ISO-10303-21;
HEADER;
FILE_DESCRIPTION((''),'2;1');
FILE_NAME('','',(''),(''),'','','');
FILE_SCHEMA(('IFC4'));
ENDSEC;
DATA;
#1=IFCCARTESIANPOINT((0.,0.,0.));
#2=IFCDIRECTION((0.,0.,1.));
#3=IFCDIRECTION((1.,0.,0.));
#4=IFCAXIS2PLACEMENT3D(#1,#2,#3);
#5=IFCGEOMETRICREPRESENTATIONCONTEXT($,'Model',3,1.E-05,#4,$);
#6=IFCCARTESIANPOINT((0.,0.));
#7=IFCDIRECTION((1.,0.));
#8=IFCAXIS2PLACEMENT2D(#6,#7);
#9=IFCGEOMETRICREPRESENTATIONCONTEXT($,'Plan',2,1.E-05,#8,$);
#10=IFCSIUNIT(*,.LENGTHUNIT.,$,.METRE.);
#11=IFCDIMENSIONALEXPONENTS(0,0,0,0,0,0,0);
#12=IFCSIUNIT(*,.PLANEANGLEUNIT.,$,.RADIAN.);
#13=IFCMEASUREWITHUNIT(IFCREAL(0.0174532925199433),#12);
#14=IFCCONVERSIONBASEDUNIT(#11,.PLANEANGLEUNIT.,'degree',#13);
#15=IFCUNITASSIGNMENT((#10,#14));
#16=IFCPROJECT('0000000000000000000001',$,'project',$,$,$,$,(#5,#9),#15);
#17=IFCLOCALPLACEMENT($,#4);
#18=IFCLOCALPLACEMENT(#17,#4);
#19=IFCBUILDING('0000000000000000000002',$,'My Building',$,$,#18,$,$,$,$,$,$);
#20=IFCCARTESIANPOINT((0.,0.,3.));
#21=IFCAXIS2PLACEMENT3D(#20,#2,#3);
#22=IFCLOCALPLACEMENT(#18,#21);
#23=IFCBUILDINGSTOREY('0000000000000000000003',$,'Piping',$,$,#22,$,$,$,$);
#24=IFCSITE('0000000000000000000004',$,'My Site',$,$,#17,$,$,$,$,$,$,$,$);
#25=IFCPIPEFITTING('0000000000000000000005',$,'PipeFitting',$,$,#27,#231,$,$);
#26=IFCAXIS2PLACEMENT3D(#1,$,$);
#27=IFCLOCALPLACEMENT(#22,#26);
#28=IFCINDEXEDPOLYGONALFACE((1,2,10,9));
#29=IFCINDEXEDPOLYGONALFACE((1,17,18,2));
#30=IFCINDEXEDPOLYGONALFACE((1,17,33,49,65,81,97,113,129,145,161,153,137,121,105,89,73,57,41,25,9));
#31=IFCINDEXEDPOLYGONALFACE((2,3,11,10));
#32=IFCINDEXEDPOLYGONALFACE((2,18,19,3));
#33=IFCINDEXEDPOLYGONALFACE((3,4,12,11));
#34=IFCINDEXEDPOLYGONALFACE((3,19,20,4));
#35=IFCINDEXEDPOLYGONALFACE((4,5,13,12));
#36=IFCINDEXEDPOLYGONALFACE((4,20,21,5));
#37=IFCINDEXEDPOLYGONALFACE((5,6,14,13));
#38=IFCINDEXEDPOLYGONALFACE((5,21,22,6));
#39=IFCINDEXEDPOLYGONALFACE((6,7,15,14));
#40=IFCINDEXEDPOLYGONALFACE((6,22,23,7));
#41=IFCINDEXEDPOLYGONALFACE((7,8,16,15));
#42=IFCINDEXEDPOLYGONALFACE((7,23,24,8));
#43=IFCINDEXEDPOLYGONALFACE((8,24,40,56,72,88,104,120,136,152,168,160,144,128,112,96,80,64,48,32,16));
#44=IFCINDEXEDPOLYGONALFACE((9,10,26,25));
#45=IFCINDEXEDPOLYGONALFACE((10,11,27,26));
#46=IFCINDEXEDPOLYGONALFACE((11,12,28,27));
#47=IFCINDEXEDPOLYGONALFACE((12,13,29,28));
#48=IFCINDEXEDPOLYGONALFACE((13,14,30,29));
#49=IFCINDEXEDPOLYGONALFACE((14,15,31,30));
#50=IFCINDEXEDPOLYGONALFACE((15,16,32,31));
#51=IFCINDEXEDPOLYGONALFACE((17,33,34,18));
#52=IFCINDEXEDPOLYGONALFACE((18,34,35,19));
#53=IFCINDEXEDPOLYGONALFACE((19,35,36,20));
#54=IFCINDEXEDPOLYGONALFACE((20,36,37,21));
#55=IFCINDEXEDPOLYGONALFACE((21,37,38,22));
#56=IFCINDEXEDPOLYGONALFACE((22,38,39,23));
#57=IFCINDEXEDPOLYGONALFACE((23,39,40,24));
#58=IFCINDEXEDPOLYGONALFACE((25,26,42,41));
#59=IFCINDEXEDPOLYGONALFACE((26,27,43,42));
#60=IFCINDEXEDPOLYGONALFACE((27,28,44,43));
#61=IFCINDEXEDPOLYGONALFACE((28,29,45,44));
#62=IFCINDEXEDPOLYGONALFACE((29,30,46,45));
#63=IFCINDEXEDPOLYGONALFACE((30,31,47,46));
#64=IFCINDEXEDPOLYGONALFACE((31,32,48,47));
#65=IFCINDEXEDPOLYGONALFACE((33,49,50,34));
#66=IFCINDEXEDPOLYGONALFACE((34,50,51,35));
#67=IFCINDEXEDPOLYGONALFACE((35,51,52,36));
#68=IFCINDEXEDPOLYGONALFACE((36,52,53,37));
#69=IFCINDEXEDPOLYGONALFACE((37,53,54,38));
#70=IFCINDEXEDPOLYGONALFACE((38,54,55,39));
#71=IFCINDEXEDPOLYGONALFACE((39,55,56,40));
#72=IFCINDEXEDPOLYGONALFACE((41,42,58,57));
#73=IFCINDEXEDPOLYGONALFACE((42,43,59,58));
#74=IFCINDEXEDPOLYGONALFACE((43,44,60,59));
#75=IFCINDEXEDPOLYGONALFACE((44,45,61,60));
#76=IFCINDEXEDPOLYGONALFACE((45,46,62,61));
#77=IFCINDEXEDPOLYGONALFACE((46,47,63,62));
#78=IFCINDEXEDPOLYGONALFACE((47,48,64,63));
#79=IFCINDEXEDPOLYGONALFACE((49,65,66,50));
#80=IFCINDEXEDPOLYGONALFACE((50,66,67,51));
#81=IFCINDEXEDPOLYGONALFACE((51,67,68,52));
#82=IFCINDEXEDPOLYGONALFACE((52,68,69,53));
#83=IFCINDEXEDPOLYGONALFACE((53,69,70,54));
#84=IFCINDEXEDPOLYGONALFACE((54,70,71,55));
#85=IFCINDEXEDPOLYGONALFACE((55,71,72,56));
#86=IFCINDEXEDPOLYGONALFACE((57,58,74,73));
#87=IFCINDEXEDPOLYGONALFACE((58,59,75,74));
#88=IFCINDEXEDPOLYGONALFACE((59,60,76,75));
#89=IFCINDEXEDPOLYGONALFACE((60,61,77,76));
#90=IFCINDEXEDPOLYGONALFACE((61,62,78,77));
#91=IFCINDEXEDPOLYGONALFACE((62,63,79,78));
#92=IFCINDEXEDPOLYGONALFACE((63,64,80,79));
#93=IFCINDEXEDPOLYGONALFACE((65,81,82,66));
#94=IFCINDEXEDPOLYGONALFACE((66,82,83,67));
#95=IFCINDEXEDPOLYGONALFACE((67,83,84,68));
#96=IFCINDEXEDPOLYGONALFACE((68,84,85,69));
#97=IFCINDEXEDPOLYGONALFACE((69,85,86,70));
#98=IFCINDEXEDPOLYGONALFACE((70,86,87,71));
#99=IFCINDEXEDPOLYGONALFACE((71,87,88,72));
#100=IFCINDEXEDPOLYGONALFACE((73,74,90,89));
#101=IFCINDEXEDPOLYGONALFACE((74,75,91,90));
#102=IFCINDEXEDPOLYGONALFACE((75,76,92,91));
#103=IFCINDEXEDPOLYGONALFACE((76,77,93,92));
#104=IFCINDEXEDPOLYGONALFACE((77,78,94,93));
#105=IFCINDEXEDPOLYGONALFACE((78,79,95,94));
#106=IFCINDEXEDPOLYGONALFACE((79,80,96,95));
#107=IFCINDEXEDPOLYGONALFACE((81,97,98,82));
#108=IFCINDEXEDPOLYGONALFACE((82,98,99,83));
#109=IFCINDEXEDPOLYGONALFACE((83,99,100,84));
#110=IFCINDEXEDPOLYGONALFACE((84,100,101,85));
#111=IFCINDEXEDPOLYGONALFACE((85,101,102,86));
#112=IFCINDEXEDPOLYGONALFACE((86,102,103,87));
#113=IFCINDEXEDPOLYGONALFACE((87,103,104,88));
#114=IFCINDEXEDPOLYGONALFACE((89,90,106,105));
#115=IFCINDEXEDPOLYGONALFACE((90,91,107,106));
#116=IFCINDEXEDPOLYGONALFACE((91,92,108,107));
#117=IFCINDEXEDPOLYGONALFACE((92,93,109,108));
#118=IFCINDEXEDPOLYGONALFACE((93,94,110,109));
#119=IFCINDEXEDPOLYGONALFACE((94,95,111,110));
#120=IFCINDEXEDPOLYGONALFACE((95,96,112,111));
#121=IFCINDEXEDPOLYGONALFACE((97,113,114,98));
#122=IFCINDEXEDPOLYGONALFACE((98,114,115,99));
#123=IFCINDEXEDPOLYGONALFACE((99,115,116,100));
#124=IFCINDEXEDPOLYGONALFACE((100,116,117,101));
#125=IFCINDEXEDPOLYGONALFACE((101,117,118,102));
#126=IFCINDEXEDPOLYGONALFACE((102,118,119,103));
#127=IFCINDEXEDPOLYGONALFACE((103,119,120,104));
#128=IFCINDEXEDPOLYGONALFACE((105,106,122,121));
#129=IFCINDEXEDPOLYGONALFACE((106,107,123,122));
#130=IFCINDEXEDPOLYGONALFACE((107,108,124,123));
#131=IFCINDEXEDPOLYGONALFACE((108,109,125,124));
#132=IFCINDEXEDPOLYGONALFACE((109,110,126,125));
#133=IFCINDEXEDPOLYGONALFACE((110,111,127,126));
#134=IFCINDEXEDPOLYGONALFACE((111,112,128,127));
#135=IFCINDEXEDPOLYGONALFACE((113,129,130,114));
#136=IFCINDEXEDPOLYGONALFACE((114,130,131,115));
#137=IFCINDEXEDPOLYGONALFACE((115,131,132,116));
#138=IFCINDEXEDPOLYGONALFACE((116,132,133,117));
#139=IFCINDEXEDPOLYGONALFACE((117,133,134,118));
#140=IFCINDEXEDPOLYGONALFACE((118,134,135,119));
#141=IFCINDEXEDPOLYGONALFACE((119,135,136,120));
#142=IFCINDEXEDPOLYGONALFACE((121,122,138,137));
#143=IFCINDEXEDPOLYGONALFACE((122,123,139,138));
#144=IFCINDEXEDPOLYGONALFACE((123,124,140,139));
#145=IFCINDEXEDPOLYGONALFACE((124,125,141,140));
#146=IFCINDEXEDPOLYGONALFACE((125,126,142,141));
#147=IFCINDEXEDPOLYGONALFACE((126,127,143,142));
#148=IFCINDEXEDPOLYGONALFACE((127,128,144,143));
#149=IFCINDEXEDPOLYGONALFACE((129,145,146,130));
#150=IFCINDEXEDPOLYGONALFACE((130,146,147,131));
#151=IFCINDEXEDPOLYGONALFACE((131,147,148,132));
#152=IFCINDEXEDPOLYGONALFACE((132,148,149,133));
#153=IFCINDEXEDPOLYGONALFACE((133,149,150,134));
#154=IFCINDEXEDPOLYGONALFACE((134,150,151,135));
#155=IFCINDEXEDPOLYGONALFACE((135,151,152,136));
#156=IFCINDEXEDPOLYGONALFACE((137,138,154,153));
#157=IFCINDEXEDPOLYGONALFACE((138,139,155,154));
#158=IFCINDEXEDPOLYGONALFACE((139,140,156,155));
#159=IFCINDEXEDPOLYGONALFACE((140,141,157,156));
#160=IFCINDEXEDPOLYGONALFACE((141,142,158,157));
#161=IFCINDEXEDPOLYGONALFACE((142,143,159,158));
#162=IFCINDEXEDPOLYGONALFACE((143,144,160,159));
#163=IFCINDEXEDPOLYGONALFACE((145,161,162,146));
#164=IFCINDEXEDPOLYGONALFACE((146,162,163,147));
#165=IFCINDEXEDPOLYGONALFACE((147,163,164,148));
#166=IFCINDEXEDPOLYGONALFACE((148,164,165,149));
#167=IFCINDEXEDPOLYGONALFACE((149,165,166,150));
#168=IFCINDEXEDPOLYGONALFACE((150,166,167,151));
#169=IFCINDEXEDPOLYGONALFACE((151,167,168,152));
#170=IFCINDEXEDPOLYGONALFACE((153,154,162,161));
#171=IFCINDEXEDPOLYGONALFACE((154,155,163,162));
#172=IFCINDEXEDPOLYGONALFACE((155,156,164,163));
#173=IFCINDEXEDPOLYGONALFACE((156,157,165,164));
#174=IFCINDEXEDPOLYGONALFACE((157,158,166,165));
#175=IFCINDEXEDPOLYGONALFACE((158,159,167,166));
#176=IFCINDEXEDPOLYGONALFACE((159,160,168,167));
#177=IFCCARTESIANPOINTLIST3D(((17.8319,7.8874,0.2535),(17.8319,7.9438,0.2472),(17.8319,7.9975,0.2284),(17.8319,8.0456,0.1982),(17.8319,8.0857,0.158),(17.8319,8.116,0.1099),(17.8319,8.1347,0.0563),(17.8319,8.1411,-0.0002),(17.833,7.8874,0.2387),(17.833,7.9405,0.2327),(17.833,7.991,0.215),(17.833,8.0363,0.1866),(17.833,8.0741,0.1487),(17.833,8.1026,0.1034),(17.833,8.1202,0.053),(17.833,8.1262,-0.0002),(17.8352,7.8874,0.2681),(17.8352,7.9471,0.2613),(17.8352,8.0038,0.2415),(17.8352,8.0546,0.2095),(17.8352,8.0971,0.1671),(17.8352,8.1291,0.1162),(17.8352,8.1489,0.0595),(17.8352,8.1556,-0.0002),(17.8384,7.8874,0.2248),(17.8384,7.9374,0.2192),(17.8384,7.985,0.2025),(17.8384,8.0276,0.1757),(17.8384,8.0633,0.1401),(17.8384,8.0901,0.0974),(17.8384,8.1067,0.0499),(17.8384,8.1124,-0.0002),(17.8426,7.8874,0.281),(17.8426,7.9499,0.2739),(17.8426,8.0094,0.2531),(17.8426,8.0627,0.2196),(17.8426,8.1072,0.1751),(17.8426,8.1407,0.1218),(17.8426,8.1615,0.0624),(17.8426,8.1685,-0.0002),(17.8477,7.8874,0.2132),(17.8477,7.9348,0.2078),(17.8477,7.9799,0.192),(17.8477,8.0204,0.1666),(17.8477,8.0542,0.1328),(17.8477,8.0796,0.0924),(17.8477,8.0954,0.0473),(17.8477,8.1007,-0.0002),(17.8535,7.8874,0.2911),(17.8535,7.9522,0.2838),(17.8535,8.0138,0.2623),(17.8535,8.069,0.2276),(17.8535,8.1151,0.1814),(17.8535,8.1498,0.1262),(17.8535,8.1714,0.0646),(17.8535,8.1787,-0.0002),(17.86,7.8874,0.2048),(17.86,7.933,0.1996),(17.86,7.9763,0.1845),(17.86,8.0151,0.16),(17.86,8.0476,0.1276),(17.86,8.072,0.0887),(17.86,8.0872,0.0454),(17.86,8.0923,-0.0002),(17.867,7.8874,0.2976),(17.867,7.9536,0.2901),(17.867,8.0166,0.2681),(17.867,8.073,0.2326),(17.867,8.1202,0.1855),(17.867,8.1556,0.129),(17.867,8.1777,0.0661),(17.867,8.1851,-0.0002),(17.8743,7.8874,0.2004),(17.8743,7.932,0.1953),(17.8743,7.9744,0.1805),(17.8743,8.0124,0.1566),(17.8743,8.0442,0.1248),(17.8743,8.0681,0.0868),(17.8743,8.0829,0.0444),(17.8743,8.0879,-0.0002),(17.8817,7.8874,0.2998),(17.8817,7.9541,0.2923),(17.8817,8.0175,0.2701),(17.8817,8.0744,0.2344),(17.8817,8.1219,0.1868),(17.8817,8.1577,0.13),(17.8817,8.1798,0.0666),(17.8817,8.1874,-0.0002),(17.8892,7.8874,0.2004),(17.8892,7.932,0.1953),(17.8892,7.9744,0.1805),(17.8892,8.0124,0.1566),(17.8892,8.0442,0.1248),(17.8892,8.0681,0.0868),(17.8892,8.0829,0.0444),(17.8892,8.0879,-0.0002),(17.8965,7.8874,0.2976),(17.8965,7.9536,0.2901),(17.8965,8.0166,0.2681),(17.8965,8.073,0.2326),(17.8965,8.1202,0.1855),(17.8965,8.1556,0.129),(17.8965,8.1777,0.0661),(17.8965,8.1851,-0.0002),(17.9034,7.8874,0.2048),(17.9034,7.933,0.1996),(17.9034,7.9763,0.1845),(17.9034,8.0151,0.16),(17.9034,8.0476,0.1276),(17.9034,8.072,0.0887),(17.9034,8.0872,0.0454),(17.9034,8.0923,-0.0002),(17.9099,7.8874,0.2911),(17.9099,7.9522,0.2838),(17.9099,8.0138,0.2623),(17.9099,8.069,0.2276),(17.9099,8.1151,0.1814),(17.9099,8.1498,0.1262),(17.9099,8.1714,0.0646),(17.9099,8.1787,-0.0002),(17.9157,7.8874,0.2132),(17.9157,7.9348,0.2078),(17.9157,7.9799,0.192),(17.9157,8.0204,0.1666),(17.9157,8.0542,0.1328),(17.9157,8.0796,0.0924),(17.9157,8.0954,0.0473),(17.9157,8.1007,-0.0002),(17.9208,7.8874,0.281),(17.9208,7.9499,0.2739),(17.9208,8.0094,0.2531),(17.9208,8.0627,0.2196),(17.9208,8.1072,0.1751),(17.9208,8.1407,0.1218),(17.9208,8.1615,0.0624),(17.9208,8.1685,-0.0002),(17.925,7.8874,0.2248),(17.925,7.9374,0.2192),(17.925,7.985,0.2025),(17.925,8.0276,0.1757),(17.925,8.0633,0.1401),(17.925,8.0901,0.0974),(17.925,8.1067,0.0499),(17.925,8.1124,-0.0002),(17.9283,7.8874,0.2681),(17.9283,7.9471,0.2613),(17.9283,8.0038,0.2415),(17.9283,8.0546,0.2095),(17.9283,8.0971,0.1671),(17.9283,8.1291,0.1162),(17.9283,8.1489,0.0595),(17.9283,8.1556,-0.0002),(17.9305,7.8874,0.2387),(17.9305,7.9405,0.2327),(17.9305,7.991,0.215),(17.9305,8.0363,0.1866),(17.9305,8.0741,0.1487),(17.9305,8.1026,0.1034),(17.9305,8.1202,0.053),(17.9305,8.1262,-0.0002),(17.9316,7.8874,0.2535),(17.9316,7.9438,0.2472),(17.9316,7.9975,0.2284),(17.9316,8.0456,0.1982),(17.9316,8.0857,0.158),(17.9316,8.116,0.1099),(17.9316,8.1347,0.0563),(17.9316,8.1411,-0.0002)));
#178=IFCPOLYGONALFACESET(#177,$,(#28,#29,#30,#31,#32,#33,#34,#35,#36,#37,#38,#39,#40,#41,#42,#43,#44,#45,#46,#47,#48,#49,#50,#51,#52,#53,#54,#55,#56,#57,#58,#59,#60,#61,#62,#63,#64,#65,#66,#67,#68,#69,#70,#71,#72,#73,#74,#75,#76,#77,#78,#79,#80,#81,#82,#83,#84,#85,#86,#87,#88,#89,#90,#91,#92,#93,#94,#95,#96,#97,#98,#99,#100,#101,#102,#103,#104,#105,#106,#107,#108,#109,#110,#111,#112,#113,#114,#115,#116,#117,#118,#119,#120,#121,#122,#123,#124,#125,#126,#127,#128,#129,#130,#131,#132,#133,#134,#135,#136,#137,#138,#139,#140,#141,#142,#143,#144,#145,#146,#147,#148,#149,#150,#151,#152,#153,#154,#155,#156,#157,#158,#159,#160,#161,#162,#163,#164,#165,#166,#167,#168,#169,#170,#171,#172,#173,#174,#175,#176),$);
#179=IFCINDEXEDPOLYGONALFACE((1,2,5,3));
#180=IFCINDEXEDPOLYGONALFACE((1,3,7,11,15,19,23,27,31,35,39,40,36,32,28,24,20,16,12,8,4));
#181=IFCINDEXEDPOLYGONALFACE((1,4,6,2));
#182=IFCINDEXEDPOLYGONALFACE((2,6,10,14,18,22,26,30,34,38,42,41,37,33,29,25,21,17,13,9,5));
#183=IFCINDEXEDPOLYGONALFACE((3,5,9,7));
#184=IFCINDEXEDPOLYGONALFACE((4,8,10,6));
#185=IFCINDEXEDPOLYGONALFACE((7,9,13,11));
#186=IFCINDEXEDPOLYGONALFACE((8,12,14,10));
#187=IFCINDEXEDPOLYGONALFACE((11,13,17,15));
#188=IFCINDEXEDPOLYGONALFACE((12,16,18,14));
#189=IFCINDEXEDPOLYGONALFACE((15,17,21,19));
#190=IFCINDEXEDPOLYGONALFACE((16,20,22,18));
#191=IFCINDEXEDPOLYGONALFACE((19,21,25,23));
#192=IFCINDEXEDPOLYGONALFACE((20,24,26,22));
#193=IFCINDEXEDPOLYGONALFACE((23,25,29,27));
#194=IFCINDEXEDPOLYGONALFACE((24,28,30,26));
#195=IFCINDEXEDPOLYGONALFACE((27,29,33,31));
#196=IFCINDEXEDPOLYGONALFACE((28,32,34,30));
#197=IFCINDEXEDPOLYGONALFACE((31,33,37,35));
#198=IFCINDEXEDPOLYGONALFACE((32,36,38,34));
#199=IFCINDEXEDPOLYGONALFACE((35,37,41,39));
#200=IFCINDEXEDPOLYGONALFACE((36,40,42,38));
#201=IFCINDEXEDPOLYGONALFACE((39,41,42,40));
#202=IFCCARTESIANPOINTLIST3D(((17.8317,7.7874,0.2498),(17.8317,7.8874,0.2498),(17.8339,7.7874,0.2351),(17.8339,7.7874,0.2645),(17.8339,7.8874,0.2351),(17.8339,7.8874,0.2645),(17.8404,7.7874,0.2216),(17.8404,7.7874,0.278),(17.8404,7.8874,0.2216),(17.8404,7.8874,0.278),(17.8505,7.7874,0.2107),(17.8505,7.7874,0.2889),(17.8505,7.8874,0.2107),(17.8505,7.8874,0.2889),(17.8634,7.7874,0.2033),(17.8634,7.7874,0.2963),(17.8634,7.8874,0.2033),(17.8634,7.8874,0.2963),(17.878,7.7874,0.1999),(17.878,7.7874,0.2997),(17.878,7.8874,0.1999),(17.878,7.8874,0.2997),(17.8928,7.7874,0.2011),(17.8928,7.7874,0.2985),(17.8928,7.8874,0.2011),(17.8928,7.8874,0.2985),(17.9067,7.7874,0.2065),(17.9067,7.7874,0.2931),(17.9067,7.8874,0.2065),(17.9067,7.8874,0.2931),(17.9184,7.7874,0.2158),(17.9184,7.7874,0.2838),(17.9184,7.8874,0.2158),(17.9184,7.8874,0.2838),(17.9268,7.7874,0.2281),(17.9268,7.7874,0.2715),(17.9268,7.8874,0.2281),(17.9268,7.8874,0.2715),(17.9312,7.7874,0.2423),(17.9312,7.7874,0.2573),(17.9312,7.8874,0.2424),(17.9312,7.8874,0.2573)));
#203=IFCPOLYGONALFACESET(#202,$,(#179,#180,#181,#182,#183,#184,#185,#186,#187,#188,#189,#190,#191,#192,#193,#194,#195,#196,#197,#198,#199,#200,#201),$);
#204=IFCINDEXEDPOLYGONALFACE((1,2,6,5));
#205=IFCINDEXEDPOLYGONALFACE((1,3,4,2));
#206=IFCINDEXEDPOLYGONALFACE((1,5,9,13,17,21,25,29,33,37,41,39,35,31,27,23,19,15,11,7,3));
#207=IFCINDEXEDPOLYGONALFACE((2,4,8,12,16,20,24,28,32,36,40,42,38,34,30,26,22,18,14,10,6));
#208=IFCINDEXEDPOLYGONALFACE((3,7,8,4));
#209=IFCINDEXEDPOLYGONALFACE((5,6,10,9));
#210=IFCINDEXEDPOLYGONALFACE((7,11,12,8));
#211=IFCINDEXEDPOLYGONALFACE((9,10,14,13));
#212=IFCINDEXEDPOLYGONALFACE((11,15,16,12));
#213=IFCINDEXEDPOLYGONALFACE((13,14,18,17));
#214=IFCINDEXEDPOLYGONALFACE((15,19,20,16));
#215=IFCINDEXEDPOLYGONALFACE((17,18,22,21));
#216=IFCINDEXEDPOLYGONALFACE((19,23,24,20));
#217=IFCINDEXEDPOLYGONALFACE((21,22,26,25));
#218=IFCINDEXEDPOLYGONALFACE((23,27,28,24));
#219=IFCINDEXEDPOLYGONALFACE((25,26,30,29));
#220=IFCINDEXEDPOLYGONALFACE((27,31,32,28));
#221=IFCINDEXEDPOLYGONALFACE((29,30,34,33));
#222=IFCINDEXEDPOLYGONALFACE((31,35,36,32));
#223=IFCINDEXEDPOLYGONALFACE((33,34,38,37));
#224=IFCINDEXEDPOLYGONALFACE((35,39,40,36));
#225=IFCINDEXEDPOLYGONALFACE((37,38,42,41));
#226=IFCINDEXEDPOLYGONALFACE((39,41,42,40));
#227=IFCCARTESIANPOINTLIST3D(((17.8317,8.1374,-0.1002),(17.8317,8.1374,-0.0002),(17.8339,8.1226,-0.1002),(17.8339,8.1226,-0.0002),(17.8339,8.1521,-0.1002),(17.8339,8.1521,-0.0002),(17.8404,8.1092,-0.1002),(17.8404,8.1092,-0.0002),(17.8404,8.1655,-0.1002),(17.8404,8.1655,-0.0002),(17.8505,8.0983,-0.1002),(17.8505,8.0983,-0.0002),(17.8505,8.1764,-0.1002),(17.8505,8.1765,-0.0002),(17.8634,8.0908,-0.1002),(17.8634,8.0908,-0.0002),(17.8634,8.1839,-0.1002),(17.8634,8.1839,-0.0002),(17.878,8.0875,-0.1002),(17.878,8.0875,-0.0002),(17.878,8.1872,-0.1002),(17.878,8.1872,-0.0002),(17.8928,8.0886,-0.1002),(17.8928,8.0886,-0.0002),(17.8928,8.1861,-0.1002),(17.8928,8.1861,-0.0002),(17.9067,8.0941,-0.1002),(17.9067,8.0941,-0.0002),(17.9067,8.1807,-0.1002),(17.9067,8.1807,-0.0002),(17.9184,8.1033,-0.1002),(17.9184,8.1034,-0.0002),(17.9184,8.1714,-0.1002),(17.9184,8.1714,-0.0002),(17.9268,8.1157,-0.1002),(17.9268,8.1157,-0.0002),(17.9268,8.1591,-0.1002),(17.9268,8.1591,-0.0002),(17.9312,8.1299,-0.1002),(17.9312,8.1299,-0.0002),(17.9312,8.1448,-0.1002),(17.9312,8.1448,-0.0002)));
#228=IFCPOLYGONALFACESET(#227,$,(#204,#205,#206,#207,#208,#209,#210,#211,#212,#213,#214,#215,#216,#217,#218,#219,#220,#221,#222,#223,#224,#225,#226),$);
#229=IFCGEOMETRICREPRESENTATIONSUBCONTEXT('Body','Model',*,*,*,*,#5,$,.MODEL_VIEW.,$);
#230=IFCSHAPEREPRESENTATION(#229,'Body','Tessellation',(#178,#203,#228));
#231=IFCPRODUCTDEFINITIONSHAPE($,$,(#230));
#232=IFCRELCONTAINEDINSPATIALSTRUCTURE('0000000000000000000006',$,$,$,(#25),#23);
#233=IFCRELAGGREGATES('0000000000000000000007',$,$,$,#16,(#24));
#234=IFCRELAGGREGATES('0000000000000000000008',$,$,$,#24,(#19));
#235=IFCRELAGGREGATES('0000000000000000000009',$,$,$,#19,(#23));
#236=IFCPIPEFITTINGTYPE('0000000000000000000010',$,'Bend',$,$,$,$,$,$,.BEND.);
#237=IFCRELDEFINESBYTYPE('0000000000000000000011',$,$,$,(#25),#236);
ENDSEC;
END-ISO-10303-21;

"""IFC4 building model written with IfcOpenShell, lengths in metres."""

from ifc_helpers import new_model, entity, si_unit, converted_unit, frame, origin_with_axes, origin_2d_with_axis, place, context, subcontext, project, spatial, circle, extrude, source, transform, mapped, type_object, type_shapes, element, save


model = new_model("IFC4")

# Units and contexts
model_context = context("Model", 3, precision=1e-05, world=origin_with_axes())
plan_context = context("Plan", 2, precision=1e-05, world=origin_2d_with_axis())
body_context = subcontext(model_context, "Body", "Model", "MODEL_VIEW")
ifc_project = project(units=[si_unit("LENGTHUNIT", "METRE"), converted_unit("PLANEANGLEUNIT", "degree", entity("IfcReal", 0.0174532925199433), si_unit("PLANEANGLEUNIT", "RADIAN"), dimensions=[0, 0, 0, 0, 0, 0, 0])], contexts=[model_context, plan_context])

# Site, building, storey
site_placement = place(None, origin_with_axes())
site = spatial("IfcSite", under=ifc_project, at=site_placement, Name="My Site")
building_placement = place(site_placement, origin_with_axes())
building = spatial("IfcBuilding", under=site, at=building_placement, Name="My Building")
storey_placement = place(building_placement, frame((0.0, 0.0, 3.0), z_axis=(0.0, 0.0, 1.0), x_axis=(1.0, 0.0, 0.0)))
storey = spatial("IfcBuildingStorey", under=building, at=storey_placement, Name="Piping")

# Pipe fitting
pipe_fitting_type_1 = type_object("IfcPipeFittingType", Name="Bend", PredefinedType="BEND")
shared_shape = source(origin_with_axes(), body_context, "Body", "SolidModel", [
    entity("IfcSweptDiskSolid", entity("IfcIndexedPolyCurve", entity("IfcCartesianPointList3D", [[0.0, 0.0, 0.1], [0.0, -0.0732, 0.2768], [0.0, -0.25, 0.35]]), [entity("IfcArcIndex", [1, 2, 3])]), 0.05),
    extrude(circle(Radius=0.05), origin_with_axes(), (0.0, 0.0, 1.0), 0.1),
    extrude(circle(Radius=0.05), frame((0.0, -0.25, 0.35), z_axis=(0.0, -1.0, -0.00003), x_axis=(1.0, 0.0, 0.0)), (0.0, 0.0, 1.0), 0.1),
])
type_shapes(pipe_fitting_type_1, [shared_shape])
for number, where, z_axis, x_axis, name in (
    (1, (17.8817, 7.7874, 0.2498), (0.0, 1.0, 0.000008), (-1.0, 0.0, 0.0), "PipeFitting"),
):
    element("IfcPipeFitting", number, at=place(storey_placement, frame(where, z_axis=z_axis, x_axis=x_axis)), inside=storey, type_object=pipe_fitting_type_1, Name=name, context=body_context, shape_type="MappedRepresentation", body=[
        mapped(shared_shape, transform((0.0, 0.0, 0.0), x_axis=(1.0, 0.0, 0.0), y_axis=(0.0, 1.0, 0.0), z_axis=(0.0, 0.0, 1.0), scale=1.0)),
    ])

save(model, "model.ifc")
